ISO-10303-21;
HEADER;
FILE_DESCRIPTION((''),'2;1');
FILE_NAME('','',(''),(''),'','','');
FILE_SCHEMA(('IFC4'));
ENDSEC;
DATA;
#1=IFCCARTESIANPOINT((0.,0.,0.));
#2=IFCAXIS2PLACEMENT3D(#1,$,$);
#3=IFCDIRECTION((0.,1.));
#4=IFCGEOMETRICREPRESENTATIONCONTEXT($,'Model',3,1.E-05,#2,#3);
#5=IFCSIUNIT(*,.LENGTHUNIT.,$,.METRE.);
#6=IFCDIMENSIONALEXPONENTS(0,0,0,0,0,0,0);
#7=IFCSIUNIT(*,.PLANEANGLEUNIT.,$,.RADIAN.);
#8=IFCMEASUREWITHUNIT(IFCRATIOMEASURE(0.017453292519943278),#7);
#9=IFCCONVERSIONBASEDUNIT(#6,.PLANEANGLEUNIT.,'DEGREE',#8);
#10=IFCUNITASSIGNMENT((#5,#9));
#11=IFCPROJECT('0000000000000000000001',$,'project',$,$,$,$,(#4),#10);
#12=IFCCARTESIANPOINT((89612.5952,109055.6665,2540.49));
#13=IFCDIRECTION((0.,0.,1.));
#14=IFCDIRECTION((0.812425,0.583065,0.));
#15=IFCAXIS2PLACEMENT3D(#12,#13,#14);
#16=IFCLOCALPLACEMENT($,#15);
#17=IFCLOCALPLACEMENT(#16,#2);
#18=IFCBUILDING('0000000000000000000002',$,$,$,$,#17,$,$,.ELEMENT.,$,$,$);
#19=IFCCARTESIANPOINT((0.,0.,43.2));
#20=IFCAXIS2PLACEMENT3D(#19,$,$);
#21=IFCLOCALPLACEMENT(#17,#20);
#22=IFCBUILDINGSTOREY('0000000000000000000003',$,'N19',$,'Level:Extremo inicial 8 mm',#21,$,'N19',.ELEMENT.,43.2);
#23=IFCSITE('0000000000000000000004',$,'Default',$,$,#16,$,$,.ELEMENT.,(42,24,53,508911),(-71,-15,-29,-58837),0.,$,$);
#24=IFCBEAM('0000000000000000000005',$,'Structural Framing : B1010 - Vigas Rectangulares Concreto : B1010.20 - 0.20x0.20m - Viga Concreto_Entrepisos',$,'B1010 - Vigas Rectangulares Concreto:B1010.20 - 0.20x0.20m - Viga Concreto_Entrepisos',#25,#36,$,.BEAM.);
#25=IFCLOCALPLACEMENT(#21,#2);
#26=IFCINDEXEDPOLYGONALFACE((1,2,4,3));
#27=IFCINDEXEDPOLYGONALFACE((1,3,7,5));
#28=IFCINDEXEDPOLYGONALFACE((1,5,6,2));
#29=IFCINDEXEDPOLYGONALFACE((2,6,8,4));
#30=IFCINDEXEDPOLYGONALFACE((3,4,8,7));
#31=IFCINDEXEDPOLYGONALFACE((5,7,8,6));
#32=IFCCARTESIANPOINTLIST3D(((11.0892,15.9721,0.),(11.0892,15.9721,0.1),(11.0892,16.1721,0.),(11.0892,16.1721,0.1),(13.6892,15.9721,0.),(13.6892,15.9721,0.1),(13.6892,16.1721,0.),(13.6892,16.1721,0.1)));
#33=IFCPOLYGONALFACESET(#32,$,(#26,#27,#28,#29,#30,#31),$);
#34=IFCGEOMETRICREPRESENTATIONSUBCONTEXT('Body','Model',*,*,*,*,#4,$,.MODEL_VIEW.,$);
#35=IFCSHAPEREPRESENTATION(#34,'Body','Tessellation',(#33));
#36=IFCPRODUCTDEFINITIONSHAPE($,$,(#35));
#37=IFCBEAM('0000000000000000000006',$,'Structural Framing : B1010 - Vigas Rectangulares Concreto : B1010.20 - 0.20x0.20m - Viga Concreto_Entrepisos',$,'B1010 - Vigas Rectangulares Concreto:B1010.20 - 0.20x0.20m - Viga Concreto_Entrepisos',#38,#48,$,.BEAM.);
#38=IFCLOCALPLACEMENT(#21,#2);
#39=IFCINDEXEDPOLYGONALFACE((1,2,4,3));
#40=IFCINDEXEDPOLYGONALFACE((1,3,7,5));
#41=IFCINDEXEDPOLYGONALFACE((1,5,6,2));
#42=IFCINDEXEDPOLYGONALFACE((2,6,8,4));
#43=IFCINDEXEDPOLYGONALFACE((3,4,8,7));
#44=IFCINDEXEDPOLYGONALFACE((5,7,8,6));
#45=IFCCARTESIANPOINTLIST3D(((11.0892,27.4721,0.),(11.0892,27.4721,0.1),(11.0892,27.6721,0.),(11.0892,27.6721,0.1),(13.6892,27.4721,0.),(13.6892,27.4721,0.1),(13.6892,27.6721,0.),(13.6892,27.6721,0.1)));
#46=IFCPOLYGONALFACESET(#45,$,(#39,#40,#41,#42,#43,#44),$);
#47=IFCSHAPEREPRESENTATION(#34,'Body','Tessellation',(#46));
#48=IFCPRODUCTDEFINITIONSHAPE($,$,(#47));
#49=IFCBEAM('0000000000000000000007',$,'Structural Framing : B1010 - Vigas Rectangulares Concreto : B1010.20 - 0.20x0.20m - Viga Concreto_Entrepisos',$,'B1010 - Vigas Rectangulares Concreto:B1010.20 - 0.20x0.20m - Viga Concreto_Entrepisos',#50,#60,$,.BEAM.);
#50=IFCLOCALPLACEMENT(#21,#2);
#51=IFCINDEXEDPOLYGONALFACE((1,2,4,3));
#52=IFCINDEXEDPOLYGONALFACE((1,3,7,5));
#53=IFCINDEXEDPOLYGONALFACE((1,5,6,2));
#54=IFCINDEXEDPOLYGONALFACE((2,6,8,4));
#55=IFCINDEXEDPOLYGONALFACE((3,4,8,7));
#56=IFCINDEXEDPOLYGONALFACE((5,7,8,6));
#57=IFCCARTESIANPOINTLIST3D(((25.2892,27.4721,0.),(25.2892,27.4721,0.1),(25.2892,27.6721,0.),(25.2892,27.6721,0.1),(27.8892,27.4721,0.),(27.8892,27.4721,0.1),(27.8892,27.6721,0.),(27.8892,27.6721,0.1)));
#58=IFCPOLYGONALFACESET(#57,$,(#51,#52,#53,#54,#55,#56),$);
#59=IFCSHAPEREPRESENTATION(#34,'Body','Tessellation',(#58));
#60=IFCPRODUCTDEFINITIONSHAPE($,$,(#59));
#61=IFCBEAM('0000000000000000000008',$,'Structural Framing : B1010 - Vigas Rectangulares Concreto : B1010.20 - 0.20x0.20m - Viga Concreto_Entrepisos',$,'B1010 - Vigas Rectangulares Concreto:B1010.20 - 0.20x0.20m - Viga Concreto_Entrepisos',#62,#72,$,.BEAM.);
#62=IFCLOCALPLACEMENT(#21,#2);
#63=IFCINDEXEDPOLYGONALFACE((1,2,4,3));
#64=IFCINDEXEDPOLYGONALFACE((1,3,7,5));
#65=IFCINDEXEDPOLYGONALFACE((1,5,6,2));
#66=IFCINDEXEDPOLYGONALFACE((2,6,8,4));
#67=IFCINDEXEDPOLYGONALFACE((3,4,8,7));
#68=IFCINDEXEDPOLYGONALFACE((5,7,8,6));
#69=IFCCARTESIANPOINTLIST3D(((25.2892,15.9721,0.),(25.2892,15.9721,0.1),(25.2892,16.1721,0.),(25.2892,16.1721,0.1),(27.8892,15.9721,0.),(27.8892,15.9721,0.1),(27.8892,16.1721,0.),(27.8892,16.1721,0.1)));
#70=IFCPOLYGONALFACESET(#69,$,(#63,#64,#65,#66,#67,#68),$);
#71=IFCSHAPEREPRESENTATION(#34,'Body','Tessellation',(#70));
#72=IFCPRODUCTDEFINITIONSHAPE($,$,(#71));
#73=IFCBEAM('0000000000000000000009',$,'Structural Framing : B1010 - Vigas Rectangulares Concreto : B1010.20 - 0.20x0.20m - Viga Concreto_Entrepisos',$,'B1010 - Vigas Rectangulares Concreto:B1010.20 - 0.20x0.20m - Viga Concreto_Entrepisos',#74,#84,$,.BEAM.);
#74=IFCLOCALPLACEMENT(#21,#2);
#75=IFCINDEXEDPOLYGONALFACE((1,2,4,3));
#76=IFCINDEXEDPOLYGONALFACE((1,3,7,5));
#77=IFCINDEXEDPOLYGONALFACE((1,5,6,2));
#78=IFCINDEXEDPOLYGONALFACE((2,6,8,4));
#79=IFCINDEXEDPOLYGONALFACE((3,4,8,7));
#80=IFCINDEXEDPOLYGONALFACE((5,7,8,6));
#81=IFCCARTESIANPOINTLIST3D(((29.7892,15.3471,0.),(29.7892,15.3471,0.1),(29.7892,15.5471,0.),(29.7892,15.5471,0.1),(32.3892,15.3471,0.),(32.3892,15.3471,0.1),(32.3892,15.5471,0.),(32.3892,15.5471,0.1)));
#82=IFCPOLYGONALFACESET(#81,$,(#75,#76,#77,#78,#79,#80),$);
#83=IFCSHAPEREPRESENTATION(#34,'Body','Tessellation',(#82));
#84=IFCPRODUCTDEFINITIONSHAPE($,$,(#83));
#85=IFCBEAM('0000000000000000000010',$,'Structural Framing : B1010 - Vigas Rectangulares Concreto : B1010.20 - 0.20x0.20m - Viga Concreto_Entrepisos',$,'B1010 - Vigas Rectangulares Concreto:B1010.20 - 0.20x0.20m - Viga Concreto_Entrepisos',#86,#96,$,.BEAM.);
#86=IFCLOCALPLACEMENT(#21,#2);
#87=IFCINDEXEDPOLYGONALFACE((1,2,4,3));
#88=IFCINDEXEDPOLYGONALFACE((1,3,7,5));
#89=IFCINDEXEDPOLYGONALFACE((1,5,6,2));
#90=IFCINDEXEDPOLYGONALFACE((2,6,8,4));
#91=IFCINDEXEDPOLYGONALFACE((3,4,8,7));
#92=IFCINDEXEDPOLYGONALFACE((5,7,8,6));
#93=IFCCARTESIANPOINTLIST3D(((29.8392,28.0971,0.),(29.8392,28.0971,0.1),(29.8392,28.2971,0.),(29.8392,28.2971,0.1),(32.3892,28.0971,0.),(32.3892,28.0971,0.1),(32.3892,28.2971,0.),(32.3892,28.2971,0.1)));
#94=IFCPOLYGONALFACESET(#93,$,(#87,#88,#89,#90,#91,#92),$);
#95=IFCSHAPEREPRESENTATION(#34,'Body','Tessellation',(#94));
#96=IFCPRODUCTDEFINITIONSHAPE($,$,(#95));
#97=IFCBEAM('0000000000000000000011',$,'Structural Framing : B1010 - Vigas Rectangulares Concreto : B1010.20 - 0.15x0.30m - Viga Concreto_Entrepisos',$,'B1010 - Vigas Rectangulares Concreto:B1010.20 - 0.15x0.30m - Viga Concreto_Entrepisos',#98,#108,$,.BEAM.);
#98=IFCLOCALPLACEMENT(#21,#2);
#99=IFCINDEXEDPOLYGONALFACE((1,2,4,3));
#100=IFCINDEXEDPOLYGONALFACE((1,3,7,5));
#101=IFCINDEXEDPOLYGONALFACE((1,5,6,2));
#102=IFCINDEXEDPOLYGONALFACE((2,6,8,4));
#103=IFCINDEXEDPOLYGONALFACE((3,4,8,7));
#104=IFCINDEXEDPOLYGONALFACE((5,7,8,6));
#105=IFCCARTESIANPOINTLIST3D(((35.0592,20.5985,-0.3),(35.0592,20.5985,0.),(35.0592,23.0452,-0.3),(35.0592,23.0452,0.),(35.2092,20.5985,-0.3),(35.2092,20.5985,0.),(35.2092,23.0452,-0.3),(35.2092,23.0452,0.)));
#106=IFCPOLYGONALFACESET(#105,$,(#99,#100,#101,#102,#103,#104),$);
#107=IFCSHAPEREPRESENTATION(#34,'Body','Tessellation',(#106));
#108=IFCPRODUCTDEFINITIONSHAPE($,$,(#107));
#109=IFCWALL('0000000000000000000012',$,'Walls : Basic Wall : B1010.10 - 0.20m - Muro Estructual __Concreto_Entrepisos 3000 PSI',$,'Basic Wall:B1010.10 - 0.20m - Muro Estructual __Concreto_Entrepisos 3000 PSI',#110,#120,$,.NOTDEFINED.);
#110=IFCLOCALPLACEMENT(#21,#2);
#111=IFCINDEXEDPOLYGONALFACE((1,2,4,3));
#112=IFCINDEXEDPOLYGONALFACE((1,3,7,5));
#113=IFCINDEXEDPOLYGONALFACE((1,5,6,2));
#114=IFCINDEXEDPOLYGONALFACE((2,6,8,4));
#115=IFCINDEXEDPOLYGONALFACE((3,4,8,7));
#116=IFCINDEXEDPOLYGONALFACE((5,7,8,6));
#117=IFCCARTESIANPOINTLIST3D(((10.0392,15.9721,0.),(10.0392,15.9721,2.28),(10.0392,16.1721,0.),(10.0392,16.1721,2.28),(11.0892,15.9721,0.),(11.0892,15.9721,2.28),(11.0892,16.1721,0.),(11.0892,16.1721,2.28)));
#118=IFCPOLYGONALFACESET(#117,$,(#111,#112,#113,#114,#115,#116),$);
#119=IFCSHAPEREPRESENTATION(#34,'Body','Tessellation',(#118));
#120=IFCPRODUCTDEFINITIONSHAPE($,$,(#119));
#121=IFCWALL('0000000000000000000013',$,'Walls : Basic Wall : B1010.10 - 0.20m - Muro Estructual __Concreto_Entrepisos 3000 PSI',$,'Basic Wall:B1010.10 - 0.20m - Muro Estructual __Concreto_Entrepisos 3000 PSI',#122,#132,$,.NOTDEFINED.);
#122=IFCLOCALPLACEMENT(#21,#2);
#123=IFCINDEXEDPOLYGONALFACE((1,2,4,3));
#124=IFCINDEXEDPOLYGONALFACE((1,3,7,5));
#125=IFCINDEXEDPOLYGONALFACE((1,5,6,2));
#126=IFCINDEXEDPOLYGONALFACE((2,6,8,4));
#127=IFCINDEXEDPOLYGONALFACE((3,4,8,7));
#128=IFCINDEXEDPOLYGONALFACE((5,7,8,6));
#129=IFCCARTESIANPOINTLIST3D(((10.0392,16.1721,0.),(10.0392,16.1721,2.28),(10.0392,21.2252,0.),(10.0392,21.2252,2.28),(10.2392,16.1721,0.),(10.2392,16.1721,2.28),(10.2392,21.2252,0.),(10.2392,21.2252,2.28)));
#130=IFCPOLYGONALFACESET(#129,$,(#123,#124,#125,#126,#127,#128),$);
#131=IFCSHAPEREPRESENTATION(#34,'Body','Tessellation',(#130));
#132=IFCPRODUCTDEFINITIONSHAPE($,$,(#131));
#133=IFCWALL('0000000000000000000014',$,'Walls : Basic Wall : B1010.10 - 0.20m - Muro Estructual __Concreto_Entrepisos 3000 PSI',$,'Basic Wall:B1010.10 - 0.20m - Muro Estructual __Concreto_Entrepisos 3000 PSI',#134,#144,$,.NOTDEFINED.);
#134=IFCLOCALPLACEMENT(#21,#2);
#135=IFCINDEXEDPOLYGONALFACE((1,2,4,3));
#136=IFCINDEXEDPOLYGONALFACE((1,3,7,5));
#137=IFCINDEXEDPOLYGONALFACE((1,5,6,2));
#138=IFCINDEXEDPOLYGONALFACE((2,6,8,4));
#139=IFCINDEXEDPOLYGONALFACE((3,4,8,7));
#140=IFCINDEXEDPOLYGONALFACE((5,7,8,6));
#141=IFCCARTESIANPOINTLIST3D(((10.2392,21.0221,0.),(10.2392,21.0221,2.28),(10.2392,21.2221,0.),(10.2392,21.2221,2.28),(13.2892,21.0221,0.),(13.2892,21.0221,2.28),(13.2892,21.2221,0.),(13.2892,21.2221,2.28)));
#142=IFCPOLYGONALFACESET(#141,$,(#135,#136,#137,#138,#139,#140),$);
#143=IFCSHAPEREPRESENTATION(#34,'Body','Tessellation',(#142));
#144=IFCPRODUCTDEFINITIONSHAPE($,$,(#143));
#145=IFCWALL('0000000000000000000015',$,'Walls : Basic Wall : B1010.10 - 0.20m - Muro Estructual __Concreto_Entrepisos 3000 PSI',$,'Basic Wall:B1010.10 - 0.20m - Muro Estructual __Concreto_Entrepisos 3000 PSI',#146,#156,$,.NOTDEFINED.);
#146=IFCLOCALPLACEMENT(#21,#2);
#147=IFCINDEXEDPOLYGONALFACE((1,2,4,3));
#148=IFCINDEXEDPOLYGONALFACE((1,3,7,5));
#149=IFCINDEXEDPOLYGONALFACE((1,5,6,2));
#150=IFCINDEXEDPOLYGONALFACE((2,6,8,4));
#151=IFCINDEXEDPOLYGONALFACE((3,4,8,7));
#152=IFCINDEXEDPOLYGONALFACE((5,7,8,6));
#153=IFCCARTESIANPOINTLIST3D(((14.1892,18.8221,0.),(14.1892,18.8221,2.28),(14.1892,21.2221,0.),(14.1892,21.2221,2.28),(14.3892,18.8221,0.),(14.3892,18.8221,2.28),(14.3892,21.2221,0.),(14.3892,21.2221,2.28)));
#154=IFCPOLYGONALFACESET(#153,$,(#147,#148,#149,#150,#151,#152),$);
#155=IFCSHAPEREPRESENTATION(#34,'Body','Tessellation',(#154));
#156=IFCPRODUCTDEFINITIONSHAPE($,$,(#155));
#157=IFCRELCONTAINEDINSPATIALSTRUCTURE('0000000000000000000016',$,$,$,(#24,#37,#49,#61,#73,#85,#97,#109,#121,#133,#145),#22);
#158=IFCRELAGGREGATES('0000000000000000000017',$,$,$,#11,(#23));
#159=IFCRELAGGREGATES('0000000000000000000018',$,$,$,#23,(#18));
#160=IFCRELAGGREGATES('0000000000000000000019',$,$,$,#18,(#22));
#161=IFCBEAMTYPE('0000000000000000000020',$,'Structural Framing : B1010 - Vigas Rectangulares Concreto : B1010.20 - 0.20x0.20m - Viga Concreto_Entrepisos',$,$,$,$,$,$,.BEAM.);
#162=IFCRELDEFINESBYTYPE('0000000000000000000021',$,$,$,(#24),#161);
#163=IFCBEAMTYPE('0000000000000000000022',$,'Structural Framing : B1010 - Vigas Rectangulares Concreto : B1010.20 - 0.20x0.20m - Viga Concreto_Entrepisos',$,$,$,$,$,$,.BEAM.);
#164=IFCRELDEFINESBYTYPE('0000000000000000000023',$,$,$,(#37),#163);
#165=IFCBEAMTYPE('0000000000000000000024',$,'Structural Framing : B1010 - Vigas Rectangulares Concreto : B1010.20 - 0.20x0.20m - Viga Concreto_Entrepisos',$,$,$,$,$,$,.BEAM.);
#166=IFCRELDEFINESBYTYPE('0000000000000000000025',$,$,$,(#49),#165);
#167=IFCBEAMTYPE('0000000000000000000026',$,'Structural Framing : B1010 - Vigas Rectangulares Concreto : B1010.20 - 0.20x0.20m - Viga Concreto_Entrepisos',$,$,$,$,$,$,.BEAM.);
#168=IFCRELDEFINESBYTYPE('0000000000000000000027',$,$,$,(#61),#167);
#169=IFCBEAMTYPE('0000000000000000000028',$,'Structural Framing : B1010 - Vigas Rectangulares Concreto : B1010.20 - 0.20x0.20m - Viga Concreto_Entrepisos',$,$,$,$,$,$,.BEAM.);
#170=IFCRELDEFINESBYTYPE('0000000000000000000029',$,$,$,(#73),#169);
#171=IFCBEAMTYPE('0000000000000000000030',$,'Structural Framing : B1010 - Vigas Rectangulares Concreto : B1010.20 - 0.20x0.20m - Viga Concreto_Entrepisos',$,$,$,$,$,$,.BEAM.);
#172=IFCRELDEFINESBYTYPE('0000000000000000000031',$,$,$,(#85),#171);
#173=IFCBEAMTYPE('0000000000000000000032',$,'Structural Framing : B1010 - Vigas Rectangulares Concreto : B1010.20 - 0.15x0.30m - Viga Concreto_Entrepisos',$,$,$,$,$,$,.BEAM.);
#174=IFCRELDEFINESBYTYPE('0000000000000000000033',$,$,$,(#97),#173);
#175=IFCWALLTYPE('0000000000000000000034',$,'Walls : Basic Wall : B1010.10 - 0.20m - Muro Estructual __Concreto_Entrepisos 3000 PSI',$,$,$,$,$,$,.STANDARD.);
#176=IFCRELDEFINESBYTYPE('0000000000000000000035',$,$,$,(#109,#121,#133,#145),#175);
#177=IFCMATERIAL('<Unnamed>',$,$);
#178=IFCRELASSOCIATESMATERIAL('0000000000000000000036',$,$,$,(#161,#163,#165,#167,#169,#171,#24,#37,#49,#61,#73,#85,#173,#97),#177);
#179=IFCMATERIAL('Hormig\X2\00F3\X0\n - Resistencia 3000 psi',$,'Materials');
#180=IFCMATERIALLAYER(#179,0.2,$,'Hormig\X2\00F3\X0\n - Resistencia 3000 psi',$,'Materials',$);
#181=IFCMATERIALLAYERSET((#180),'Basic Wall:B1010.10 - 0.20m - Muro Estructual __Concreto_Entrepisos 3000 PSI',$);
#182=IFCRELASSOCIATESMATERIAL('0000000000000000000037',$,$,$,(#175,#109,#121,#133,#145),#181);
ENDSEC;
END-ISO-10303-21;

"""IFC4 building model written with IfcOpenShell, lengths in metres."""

from ifc_helpers import new_model, entity, si_unit, converted_unit, direction, frame, frame_2d, origin, place, context, subcontext, project, spatial, polyline, segment, composite_curve, rectangle, outline, extrude, source, transform, mapped, material, layer, layer_set, layer_usage, material_profile, profile_set, profile_usage, type_object, type_shapes, element, save


model = new_model("IFC4")

# Units and contexts
model_context = context("Model", 3, precision=1e-05, world=origin(), true_north=direction((0.0, 1.0)))
body_context = subcontext(model_context, "Body", "Model", "MODEL_VIEW")
ifc_project = project(units=[si_unit("LENGTHUNIT", "METRE"), converted_unit("PLANEANGLEUNIT", "DEGREE", entity("IfcRatioMeasure", 0.017453292519943278), si_unit("PLANEANGLEUNIT", "RADIAN"), dimensions=[0, 0, 0, 0, 0, 0, 0])], contexts=[model_context])

# Site, building, storey
site_placement = place(None, frame((89612.5952, 109055.6665, 2540.49), z_axis=(0.0, 0.0, 1.0), x_axis=(0.812425, 0.583065, 0.0)))
site = spatial("IfcSite", under=ifc_project, at=site_placement, Name="Default", CompositionType="ELEMENT", RefLatitude=(42, 24, 53, 508911), RefLongitude=(-71, -15, -29, -58837), RefElevation=0.0)
building_placement = place(site_placement, origin())
building = spatial("IfcBuilding", under=site, at=building_placement, CompositionType="ELEMENT")
storey_placement = place(building_placement, frame((0.0, 0.0, 43.2)))
storey = spatial("IfcBuildingStorey", under=building, at=storey_placement, Name="N19", ObjectType="Level:Extremo inicial 8 mm", LongName="N19", CompositionType="ELEMENT", Elevation=43.2)

# Beams
ifc_material_1 = material(Name="<Unnamed>")
ifc_material_profile_1 = material_profile(ifc_material_1, outline(composite_curve([segment(polyline([(-0.1, 0.0, 0.0), (-0.1, 0.1, 0.0)]), True, "CONTINUOUS"), segment(polyline([(-0.1, 0.1, 0.0), (0.1, 0.1, 0.0)]), True, "CONTINUOUS"), segment(polyline([(0.1, 0.1, 0.0), (0.1, 0.0, 0.0)]), True, "CONTINUOUS"), segment(polyline([(0.1, 0.0, 0.0), (-0.1, 0.0, 0.0)]), True, "CONTINUOUS")], self_intersect=False), kind="CURVE"), Name="B1010.20 - 0.20x0.20m - Viga Concreto_Entrepisos")
ifc_material_profile_2 = material_profile(ifc_material_1, outline(composite_curve([segment(polyline([(-1.3, -0.1, 0.1), (-1.3, 0.1, 0.1)]), True, "CONTINUOUS"), segment(polyline([(-1.3, 0.1, 0.1), (-1.3, 0.1, -0.1)]), True, "CONTINUOUS"), segment(polyline([(-1.3, 0.1, -0.1), (-1.3, -0.1, -0.1)]), True, "CONTINUOUS"), segment(polyline([(-1.3, -0.1, -0.1), (-1.3, -0.1, 0.1)]), True, "CONTINUOUS")], self_intersect=False), kind="CURVE"), Name="B1010.20 - 0.20x0.20m - Viga Concreto_Entrepisos")
ifc_profile_set_1 = profile_set([ifc_material_profile_1, ifc_material_profile_2], Name="B1010.20 - 0.20x0.20m - Viga Concreto_Entrepisos")
ifc_profile_usage_1 = profile_usage(ifc_profile_set_1, cardinal=8)
beam_type_1 = type_object("IfcBeamType", Name="Structural Framing : B1010 - Vigas Rectangulares Concreto : B1010.20 - 0.20x0.20m - Viga Concreto_Entrepisos", PredefinedType="BEAM", material=ifc_profile_set_1)
shared_shape_1 = source(origin(), body_context, "Body", "SweptSolid", [
    extrude(rectangle(XDim=0.1, YDim=0.2, at=frame_2d((0.0, 0.0), x_axis=(1.0, 0.0))), frame((13.6892, 16.0721, 43.25), z_axis=(-1.0, 0.0, 0.0), x_axis=(0.0, 0.0, -1.0)), (0.0, 0.0, 1.0), 2.6),
])
type_shapes(beam_type_1, [shared_shape_1])
beam_1_placement = place(storey_placement, frame((0.0, 0.0, -43.2)))
element("IfcBeam", 1, at=beam_1_placement, inside=storey, type_object=beam_type_1, material=ifc_profile_usage_1, Name="Structural Framing : B1010 - Vigas Rectangulares Concreto : B1010.20 - 0.20x0.20m - Viga Concreto_Entrepisos", ObjectType="B1010 - Vigas Rectangulares Concreto:B1010.20 - 0.20x0.20m - Viga Concreto_Entrepisos", PredefinedType="BEAM", context=body_context, shape_type="MappedRepresentation", body=[
    mapped(shared_shape_1, transform((0.0, 0.0, 0.0), scale=1.0)),
])
ifc_profile_usage_2 = profile_usage(ifc_profile_set_1, cardinal=8)
beam_type_2 = type_object("IfcBeamType", Name="Structural Framing : B1010 - Vigas Rectangulares Concreto : B1010.20 - 0.20x0.20m - Viga Concreto_Entrepisos", PredefinedType="BEAM", material=ifc_profile_set_1)
shared_shape_2 = source(origin(), body_context, "Body", "SweptSolid", [
    extrude(rectangle(XDim=0.1, YDim=0.2, at=frame_2d((0.0, 0.0), x_axis=(1.0, 0.0))), frame((13.6892, 27.5721, 43.25), z_axis=(-1.0, 0.0, 0.0), x_axis=(0.0, 0.0, -1.0)), (0.0, 0.0, 1.0), 2.6),
])
type_shapes(beam_type_2, [shared_shape_2])
beam_2_placement = place(storey_placement, frame((0.0, 0.0, -43.2)))
element("IfcBeam", 2, at=beam_2_placement, inside=storey, type_object=beam_type_2, material=ifc_profile_usage_2, Name="Structural Framing : B1010 - Vigas Rectangulares Concreto : B1010.20 - 0.20x0.20m - Viga Concreto_Entrepisos", ObjectType="B1010 - Vigas Rectangulares Concreto:B1010.20 - 0.20x0.20m - Viga Concreto_Entrepisos", PredefinedType="BEAM", context=body_context, shape_type="MappedRepresentation", body=[
    mapped(shared_shape_2, transform((0.0, 0.0, 0.0), scale=1.0)),
])
ifc_profile_usage_3 = profile_usage(ifc_profile_set_1, cardinal=8)
beam_type_3 = type_object("IfcBeamType", Name="Structural Framing : B1010 - Vigas Rectangulares Concreto : B1010.20 - 0.20x0.20m - Viga Concreto_Entrepisos", PredefinedType="BEAM", material=ifc_profile_set_1)
shared_shape_3 = source(origin(), body_context, "Body", "SweptSolid", [
    extrude(rectangle(XDim=0.1, YDim=0.2, at=frame_2d((0.0, 0.0), x_axis=(1.0, 0.0))), frame((25.2892, 27.5721, 43.25), z_axis=(1.0, 0.0, 0.0), x_axis=(0.0, 0.0, -1.0)), (0.0, 0.0, 1.0), 2.6),
])
type_shapes(beam_type_3, [shared_shape_3])
beam_3_placement = place(storey_placement, frame((0.0, 0.0, -43.2)))
element("IfcBeam", 3, at=beam_3_placement, inside=storey, type_object=beam_type_3, material=ifc_profile_usage_3, Name="Structural Framing : B1010 - Vigas Rectangulares Concreto : B1010.20 - 0.20x0.20m - Viga Concreto_Entrepisos", ObjectType="B1010 - Vigas Rectangulares Concreto:B1010.20 - 0.20x0.20m - Viga Concreto_Entrepisos", PredefinedType="BEAM", context=body_context, shape_type="MappedRepresentation", body=[
    mapped(shared_shape_3, transform((0.0, 0.0, 0.0), scale=1.0)),
])
ifc_profile_usage_4 = profile_usage(ifc_profile_set_1, cardinal=8)
beam_type_4 = type_object("IfcBeamType", Name="Structural Framing : B1010 - Vigas Rectangulares Concreto : B1010.20 - 0.20x0.20m - Viga Concreto_Entrepisos", PredefinedType="BEAM", material=ifc_profile_set_1)
shared_shape_4 = source(origin(), body_context, "Body", "SweptSolid", [
    extrude(rectangle(XDim=0.1, YDim=0.2, at=frame_2d((0.0, 0.0), x_axis=(1.0, 0.0))), frame((25.2892, 16.0721, 43.25), z_axis=(1.0, 0.0, 0.0), x_axis=(0.0, 0.0, -1.0)), (0.0, 0.0, 1.0), 2.6),
])
type_shapes(beam_type_4, [shared_shape_4])
beam_4_placement = place(storey_placement, frame((0.0, 0.0, -43.2)))
element("IfcBeam", 4, at=beam_4_placement, inside=storey, type_object=beam_type_4, material=ifc_profile_usage_4, Name="Structural Framing : B1010 - Vigas Rectangulares Concreto : B1010.20 - 0.20x0.20m - Viga Concreto_Entrepisos", ObjectType="B1010 - Vigas Rectangulares Concreto:B1010.20 - 0.20x0.20m - Viga Concreto_Entrepisos", PredefinedType="BEAM", context=body_context, shape_type="MappedRepresentation", body=[
    mapped(shared_shape_4, transform((0.0, 0.0, 0.0), scale=1.0)),
])
ifc_profile_usage_5 = profile_usage(ifc_profile_set_1, cardinal=8)
beam_type_5 = type_object("IfcBeamType", Name="Structural Framing : B1010 - Vigas Rectangulares Concreto : B1010.20 - 0.20x0.20m - Viga Concreto_Entrepisos", PredefinedType="BEAM", material=ifc_profile_set_1)
shared_shape_5 = source(origin(), body_context, "Body", "SweptSolid", [
    extrude(rectangle(XDim=0.1, YDim=0.2, at=frame_2d((0.0, 0.0), x_axis=(1.0, 0.0))), frame((32.3892, 15.4471, 43.25), z_axis=(-1.0, 0.0, 0.0), x_axis=(0.0, 0.0, -1.0)), (0.0, 0.0, 1.0), 2.6),
])
type_shapes(beam_type_5, [shared_shape_5])
beam_5_placement = place(storey_placement, frame((0.0, 0.0, -43.2)))
element("IfcBeam", 5, at=beam_5_placement, inside=storey, type_object=beam_type_5, material=ifc_profile_usage_5, Name="Structural Framing : B1010 - Vigas Rectangulares Concreto : B1010.20 - 0.20x0.20m - Viga Concreto_Entrepisos", ObjectType="B1010 - Vigas Rectangulares Concreto:B1010.20 - 0.20x0.20m - Viga Concreto_Entrepisos", PredefinedType="BEAM", context=body_context, shape_type="MappedRepresentation", body=[
    mapped(shared_shape_5, transform((0.0, 0.0, 0.0), scale=1.0)),
])
ifc_profile_usage_6 = profile_usage(ifc_profile_set_1, cardinal=8)
beam_type_6 = type_object("IfcBeamType", Name="Structural Framing : B1010 - Vigas Rectangulares Concreto : B1010.20 - 0.20x0.20m - Viga Concreto_Entrepisos", PredefinedType="BEAM", material=ifc_profile_set_1)
shared_shape_6 = source(origin(), body_context, "Body", "SweptSolid", [
    extrude(rectangle(XDim=0.1, YDim=0.2, at=frame_2d((0.0, 0.0), x_axis=(1.0, 0.0))), frame((29.8392, 28.1971, 43.25), z_axis=(1.0, 0.0, 0.0), x_axis=(0.0, 0.0, -1.0)), (0.0, 0.0, 1.0), 2.55),
])
type_shapes(beam_type_6, [shared_shape_6])
beam_6_placement = place(storey_placement, frame((0.0, 0.0, -43.2)))
element("IfcBeam", 6, at=beam_6_placement, inside=storey, type_object=beam_type_6, material=ifc_profile_usage_6, Name="Structural Framing : B1010 - Vigas Rectangulares Concreto : B1010.20 - 0.20x0.20m - Viga Concreto_Entrepisos", ObjectType="B1010 - Vigas Rectangulares Concreto:B1010.20 - 0.20x0.20m - Viga Concreto_Entrepisos", PredefinedType="BEAM", context=body_context, shape_type="MappedRepresentation", body=[
    mapped(shared_shape_6, transform((0.0, 0.0, 0.0), scale=1.0)),
])
ifc_material_profile_3 = material_profile(ifc_material_1, outline(composite_curve([segment(polyline([(-0.075, -0.15, 0.0), (-0.075, 0.15, 0.0)]), True, "CONTINUOUS"), segment(polyline([(-0.075, 0.15, 0.0), (0.075, 0.15, 0.0)]), True, "CONTINUOUS"), segment(polyline([(0.075, 0.15, 0.0), (0.075, -0.15, 0.0)]), True, "CONTINUOUS"), segment(polyline([(0.075, -0.15, 0.0), (-0.075, -0.15, 0.0)]), True, "CONTINUOUS")], self_intersect=False), kind="CURVE"), Name="B1010.20 - 0.15x0.30m - Viga Concreto_Entrepisos")
ifc_material_profile_4 = material_profile(ifc_material_1, outline(composite_curve([segment(polyline([(1.2233, 0.075, 0.15), (1.2233, 0.075, -0.15)]), True, "CONTINUOUS"), segment(polyline([(1.2233, 0.075, -0.15), (-1.2233, 0.075, -0.15)]), True, "CONTINUOUS"), segment(polyline([(-1.2233, 0.075, -0.15), (-1.2233, 0.075, 0.15)]), True, "CONTINUOUS"), segment(polyline([(-1.2233, 0.075, 0.15), (1.2233, 0.075, 0.15)]), True, "CONTINUOUS")], self_intersect=False), kind="CURVE"), Name="B1010.20 - 0.15x0.30m - Viga Concreto_Entrepisos")
ifc_profile_set_2 = profile_set([ifc_material_profile_3, ifc_material_profile_4], Name="B1010.20 - 0.15x0.30m - Viga Concreto_Entrepisos")
ifc_profile_usage_7 = profile_usage(ifc_profile_set_2, cardinal=8)
beam_type_7 = type_object("IfcBeamType", Name="Structural Framing : B1010 - Vigas Rectangulares Concreto : B1010.20 - 0.15x0.30m - Viga Concreto_Entrepisos", PredefinedType="BEAM", material=ifc_profile_set_2)
shared_shape_7 = source(origin(), body_context, "Body", "SweptSolid", [
    extrude(rectangle(XDim=0.3, YDim=0.15, at=frame_2d((0.0, 0.0), x_axis=(0.0, 1.0))), frame((35.1342, 20.5985, 43.05), z_axis=(0.0, 1.0, 0.0), x_axis=(-1.0, 0.0, 0.0)), (0.0, 0.0, 1.0), 2.4467),
])
type_shapes(beam_type_7, [shared_shape_7])
beam_7_placement = place(storey_placement, frame((0.0, 0.0, -43.2)))
element("IfcBeam", 7, at=beam_7_placement, inside=storey, type_object=beam_type_7, material=ifc_profile_usage_7, Name="Structural Framing : B1010 - Vigas Rectangulares Concreto : B1010.20 - 0.15x0.30m - Viga Concreto_Entrepisos", ObjectType="B1010 - Vigas Rectangulares Concreto:B1010.20 - 0.15x0.30m - Viga Concreto_Entrepisos", PredefinedType="BEAM", context=body_context, shape_type="MappedRepresentation", body=[
    mapped(shared_shape_7, transform((0.0, 0.0, 0.0), scale=1.0)),
])

# Walls
ifc_material_2 = material(Name="Hormigón - Resistencia 3000 psi", Category="Materials")
ifc_layer_1 = layer(ifc_material_2, 0.2, Name="Hormigón - Resistencia 3000 psi", Category="Materials")
ifc_layer_set_1 = layer_set([ifc_layer_1], Name="Basic Wall:B1010.10 - 0.20m - Muro Estructual __Concreto_Entrepisos 3000 PSI")
ifc_layer_usage_1 = layer_usage(ifc_layer_set_1, "AXIS2", "NEGATIVE", 0.1)
wall_type_1 = type_object("IfcWallType", Name="Walls : Basic Wall : B1010.10 - 0.20m - Muro Estructual __Concreto_Entrepisos 3000 PSI", PredefinedType="STANDARD", material=ifc_layer_set_1)
wall_1_placement = place(storey_placement, frame((11.0892, 16.0721, 0.0), z_axis=(0.0, 0.0, 1.0), x_axis=(-1.0, 0.0, 0.0)))
element("IfcWall", 8, at=wall_1_placement, inside=storey, type_object=wall_type_1, material=ifc_layer_usage_1, Name="Walls : Basic Wall : B1010.10 - 0.20m - Muro Estructual __Concreto_Entrepisos 3000 PSI", ObjectType="Basic Wall:B1010.10 - 0.20m - Muro Estructual __Concreto_Entrepisos 3000 PSI", PredefinedType="NOTDEFINED", context=body_context, shape_type="SweptSolid", body=[
    extrude(rectangle(XDim=1.05, YDim=0.2, at=frame_2d((0.525, 0.0), x_axis=(-1.0, 0.0))), origin(), (0.0, 0.0, 1.0), 2.28),
])
ifc_layer_usage_2 = layer_usage(ifc_layer_set_1, "AXIS2", "NEGATIVE", 0.1)
wall_2_placement = place(storey_placement, frame((10.1392, 16.1721, 0.0), z_axis=(0.0, 0.0, 1.0), x_axis=(0.0, 1.0, 0.0)))
element("IfcWall", 9, at=wall_2_placement, inside=storey, type_object=wall_type_1, material=ifc_layer_usage_2, Name="Walls : Basic Wall : B1010.10 - 0.20m - Muro Estructual __Concreto_Entrepisos 3000 PSI", ObjectType="Basic Wall:B1010.10 - 0.20m - Muro Estructual __Concreto_Entrepisos 3000 PSI", PredefinedType="NOTDEFINED", context=body_context, shape_type="SweptSolid", body=[
    extrude(rectangle(XDim=5.0531, YDim=0.2, at=frame_2d((2.5265, 0.0), x_axis=(-1.0, 0.0))), origin(), (0.0, 0.0, 1.0), 2.28),
])
ifc_layer_usage_3 = layer_usage(ifc_layer_set_1, "AXIS2", "NEGATIVE", 0.1)
wall_3_placement = place(storey_placement, frame((10.2392, 21.1221, 0.0)))
element("IfcWall", 10, at=wall_3_placement, inside=storey, type_object=wall_type_1, material=ifc_layer_usage_3, Name="Walls : Basic Wall : B1010.10 - 0.20m - Muro Estructual __Concreto_Entrepisos 3000 PSI", ObjectType="Basic Wall:B1010.10 - 0.20m - Muro Estructual __Concreto_Entrepisos 3000 PSI", PredefinedType="NOTDEFINED", context=body_context, shape_type="SweptSolid", body=[
    extrude(rectangle(XDim=3.05, YDim=0.2, at=frame_2d((1.525, 0.0), x_axis=(-1.0, 0.0))), origin(), (0.0, 0.0, 1.0), 2.28),
])
ifc_layer_usage_4 = layer_usage(ifc_layer_set_1, "AXIS2", "NEGATIVE", 0.1)
wall_4_placement = place(storey_placement, frame((14.2892, 18.8221, 0.0), z_axis=(0.0, 0.0, 1.0), x_axis=(0.0, 1.0, 0.0)))
element("IfcWall", 11, at=wall_4_placement, inside=storey, type_object=wall_type_1, material=ifc_layer_usage_4, Name="Walls : Basic Wall : B1010.10 - 0.20m - Muro Estructual __Concreto_Entrepisos 3000 PSI", ObjectType="Basic Wall:B1010.10 - 0.20m - Muro Estructual __Concreto_Entrepisos 3000 PSI", PredefinedType="NOTDEFINED", context=body_context, shape_type="SweptSolid", body=[
    extrude(rectangle(XDim=2.4, YDim=0.2, at=frame_2d((1.2, 0.0), x_axis=(-1.0, 0.0))), origin(), (0.0, 0.0, 1.0), 2.28),
])

save(model, "model.ifc")
